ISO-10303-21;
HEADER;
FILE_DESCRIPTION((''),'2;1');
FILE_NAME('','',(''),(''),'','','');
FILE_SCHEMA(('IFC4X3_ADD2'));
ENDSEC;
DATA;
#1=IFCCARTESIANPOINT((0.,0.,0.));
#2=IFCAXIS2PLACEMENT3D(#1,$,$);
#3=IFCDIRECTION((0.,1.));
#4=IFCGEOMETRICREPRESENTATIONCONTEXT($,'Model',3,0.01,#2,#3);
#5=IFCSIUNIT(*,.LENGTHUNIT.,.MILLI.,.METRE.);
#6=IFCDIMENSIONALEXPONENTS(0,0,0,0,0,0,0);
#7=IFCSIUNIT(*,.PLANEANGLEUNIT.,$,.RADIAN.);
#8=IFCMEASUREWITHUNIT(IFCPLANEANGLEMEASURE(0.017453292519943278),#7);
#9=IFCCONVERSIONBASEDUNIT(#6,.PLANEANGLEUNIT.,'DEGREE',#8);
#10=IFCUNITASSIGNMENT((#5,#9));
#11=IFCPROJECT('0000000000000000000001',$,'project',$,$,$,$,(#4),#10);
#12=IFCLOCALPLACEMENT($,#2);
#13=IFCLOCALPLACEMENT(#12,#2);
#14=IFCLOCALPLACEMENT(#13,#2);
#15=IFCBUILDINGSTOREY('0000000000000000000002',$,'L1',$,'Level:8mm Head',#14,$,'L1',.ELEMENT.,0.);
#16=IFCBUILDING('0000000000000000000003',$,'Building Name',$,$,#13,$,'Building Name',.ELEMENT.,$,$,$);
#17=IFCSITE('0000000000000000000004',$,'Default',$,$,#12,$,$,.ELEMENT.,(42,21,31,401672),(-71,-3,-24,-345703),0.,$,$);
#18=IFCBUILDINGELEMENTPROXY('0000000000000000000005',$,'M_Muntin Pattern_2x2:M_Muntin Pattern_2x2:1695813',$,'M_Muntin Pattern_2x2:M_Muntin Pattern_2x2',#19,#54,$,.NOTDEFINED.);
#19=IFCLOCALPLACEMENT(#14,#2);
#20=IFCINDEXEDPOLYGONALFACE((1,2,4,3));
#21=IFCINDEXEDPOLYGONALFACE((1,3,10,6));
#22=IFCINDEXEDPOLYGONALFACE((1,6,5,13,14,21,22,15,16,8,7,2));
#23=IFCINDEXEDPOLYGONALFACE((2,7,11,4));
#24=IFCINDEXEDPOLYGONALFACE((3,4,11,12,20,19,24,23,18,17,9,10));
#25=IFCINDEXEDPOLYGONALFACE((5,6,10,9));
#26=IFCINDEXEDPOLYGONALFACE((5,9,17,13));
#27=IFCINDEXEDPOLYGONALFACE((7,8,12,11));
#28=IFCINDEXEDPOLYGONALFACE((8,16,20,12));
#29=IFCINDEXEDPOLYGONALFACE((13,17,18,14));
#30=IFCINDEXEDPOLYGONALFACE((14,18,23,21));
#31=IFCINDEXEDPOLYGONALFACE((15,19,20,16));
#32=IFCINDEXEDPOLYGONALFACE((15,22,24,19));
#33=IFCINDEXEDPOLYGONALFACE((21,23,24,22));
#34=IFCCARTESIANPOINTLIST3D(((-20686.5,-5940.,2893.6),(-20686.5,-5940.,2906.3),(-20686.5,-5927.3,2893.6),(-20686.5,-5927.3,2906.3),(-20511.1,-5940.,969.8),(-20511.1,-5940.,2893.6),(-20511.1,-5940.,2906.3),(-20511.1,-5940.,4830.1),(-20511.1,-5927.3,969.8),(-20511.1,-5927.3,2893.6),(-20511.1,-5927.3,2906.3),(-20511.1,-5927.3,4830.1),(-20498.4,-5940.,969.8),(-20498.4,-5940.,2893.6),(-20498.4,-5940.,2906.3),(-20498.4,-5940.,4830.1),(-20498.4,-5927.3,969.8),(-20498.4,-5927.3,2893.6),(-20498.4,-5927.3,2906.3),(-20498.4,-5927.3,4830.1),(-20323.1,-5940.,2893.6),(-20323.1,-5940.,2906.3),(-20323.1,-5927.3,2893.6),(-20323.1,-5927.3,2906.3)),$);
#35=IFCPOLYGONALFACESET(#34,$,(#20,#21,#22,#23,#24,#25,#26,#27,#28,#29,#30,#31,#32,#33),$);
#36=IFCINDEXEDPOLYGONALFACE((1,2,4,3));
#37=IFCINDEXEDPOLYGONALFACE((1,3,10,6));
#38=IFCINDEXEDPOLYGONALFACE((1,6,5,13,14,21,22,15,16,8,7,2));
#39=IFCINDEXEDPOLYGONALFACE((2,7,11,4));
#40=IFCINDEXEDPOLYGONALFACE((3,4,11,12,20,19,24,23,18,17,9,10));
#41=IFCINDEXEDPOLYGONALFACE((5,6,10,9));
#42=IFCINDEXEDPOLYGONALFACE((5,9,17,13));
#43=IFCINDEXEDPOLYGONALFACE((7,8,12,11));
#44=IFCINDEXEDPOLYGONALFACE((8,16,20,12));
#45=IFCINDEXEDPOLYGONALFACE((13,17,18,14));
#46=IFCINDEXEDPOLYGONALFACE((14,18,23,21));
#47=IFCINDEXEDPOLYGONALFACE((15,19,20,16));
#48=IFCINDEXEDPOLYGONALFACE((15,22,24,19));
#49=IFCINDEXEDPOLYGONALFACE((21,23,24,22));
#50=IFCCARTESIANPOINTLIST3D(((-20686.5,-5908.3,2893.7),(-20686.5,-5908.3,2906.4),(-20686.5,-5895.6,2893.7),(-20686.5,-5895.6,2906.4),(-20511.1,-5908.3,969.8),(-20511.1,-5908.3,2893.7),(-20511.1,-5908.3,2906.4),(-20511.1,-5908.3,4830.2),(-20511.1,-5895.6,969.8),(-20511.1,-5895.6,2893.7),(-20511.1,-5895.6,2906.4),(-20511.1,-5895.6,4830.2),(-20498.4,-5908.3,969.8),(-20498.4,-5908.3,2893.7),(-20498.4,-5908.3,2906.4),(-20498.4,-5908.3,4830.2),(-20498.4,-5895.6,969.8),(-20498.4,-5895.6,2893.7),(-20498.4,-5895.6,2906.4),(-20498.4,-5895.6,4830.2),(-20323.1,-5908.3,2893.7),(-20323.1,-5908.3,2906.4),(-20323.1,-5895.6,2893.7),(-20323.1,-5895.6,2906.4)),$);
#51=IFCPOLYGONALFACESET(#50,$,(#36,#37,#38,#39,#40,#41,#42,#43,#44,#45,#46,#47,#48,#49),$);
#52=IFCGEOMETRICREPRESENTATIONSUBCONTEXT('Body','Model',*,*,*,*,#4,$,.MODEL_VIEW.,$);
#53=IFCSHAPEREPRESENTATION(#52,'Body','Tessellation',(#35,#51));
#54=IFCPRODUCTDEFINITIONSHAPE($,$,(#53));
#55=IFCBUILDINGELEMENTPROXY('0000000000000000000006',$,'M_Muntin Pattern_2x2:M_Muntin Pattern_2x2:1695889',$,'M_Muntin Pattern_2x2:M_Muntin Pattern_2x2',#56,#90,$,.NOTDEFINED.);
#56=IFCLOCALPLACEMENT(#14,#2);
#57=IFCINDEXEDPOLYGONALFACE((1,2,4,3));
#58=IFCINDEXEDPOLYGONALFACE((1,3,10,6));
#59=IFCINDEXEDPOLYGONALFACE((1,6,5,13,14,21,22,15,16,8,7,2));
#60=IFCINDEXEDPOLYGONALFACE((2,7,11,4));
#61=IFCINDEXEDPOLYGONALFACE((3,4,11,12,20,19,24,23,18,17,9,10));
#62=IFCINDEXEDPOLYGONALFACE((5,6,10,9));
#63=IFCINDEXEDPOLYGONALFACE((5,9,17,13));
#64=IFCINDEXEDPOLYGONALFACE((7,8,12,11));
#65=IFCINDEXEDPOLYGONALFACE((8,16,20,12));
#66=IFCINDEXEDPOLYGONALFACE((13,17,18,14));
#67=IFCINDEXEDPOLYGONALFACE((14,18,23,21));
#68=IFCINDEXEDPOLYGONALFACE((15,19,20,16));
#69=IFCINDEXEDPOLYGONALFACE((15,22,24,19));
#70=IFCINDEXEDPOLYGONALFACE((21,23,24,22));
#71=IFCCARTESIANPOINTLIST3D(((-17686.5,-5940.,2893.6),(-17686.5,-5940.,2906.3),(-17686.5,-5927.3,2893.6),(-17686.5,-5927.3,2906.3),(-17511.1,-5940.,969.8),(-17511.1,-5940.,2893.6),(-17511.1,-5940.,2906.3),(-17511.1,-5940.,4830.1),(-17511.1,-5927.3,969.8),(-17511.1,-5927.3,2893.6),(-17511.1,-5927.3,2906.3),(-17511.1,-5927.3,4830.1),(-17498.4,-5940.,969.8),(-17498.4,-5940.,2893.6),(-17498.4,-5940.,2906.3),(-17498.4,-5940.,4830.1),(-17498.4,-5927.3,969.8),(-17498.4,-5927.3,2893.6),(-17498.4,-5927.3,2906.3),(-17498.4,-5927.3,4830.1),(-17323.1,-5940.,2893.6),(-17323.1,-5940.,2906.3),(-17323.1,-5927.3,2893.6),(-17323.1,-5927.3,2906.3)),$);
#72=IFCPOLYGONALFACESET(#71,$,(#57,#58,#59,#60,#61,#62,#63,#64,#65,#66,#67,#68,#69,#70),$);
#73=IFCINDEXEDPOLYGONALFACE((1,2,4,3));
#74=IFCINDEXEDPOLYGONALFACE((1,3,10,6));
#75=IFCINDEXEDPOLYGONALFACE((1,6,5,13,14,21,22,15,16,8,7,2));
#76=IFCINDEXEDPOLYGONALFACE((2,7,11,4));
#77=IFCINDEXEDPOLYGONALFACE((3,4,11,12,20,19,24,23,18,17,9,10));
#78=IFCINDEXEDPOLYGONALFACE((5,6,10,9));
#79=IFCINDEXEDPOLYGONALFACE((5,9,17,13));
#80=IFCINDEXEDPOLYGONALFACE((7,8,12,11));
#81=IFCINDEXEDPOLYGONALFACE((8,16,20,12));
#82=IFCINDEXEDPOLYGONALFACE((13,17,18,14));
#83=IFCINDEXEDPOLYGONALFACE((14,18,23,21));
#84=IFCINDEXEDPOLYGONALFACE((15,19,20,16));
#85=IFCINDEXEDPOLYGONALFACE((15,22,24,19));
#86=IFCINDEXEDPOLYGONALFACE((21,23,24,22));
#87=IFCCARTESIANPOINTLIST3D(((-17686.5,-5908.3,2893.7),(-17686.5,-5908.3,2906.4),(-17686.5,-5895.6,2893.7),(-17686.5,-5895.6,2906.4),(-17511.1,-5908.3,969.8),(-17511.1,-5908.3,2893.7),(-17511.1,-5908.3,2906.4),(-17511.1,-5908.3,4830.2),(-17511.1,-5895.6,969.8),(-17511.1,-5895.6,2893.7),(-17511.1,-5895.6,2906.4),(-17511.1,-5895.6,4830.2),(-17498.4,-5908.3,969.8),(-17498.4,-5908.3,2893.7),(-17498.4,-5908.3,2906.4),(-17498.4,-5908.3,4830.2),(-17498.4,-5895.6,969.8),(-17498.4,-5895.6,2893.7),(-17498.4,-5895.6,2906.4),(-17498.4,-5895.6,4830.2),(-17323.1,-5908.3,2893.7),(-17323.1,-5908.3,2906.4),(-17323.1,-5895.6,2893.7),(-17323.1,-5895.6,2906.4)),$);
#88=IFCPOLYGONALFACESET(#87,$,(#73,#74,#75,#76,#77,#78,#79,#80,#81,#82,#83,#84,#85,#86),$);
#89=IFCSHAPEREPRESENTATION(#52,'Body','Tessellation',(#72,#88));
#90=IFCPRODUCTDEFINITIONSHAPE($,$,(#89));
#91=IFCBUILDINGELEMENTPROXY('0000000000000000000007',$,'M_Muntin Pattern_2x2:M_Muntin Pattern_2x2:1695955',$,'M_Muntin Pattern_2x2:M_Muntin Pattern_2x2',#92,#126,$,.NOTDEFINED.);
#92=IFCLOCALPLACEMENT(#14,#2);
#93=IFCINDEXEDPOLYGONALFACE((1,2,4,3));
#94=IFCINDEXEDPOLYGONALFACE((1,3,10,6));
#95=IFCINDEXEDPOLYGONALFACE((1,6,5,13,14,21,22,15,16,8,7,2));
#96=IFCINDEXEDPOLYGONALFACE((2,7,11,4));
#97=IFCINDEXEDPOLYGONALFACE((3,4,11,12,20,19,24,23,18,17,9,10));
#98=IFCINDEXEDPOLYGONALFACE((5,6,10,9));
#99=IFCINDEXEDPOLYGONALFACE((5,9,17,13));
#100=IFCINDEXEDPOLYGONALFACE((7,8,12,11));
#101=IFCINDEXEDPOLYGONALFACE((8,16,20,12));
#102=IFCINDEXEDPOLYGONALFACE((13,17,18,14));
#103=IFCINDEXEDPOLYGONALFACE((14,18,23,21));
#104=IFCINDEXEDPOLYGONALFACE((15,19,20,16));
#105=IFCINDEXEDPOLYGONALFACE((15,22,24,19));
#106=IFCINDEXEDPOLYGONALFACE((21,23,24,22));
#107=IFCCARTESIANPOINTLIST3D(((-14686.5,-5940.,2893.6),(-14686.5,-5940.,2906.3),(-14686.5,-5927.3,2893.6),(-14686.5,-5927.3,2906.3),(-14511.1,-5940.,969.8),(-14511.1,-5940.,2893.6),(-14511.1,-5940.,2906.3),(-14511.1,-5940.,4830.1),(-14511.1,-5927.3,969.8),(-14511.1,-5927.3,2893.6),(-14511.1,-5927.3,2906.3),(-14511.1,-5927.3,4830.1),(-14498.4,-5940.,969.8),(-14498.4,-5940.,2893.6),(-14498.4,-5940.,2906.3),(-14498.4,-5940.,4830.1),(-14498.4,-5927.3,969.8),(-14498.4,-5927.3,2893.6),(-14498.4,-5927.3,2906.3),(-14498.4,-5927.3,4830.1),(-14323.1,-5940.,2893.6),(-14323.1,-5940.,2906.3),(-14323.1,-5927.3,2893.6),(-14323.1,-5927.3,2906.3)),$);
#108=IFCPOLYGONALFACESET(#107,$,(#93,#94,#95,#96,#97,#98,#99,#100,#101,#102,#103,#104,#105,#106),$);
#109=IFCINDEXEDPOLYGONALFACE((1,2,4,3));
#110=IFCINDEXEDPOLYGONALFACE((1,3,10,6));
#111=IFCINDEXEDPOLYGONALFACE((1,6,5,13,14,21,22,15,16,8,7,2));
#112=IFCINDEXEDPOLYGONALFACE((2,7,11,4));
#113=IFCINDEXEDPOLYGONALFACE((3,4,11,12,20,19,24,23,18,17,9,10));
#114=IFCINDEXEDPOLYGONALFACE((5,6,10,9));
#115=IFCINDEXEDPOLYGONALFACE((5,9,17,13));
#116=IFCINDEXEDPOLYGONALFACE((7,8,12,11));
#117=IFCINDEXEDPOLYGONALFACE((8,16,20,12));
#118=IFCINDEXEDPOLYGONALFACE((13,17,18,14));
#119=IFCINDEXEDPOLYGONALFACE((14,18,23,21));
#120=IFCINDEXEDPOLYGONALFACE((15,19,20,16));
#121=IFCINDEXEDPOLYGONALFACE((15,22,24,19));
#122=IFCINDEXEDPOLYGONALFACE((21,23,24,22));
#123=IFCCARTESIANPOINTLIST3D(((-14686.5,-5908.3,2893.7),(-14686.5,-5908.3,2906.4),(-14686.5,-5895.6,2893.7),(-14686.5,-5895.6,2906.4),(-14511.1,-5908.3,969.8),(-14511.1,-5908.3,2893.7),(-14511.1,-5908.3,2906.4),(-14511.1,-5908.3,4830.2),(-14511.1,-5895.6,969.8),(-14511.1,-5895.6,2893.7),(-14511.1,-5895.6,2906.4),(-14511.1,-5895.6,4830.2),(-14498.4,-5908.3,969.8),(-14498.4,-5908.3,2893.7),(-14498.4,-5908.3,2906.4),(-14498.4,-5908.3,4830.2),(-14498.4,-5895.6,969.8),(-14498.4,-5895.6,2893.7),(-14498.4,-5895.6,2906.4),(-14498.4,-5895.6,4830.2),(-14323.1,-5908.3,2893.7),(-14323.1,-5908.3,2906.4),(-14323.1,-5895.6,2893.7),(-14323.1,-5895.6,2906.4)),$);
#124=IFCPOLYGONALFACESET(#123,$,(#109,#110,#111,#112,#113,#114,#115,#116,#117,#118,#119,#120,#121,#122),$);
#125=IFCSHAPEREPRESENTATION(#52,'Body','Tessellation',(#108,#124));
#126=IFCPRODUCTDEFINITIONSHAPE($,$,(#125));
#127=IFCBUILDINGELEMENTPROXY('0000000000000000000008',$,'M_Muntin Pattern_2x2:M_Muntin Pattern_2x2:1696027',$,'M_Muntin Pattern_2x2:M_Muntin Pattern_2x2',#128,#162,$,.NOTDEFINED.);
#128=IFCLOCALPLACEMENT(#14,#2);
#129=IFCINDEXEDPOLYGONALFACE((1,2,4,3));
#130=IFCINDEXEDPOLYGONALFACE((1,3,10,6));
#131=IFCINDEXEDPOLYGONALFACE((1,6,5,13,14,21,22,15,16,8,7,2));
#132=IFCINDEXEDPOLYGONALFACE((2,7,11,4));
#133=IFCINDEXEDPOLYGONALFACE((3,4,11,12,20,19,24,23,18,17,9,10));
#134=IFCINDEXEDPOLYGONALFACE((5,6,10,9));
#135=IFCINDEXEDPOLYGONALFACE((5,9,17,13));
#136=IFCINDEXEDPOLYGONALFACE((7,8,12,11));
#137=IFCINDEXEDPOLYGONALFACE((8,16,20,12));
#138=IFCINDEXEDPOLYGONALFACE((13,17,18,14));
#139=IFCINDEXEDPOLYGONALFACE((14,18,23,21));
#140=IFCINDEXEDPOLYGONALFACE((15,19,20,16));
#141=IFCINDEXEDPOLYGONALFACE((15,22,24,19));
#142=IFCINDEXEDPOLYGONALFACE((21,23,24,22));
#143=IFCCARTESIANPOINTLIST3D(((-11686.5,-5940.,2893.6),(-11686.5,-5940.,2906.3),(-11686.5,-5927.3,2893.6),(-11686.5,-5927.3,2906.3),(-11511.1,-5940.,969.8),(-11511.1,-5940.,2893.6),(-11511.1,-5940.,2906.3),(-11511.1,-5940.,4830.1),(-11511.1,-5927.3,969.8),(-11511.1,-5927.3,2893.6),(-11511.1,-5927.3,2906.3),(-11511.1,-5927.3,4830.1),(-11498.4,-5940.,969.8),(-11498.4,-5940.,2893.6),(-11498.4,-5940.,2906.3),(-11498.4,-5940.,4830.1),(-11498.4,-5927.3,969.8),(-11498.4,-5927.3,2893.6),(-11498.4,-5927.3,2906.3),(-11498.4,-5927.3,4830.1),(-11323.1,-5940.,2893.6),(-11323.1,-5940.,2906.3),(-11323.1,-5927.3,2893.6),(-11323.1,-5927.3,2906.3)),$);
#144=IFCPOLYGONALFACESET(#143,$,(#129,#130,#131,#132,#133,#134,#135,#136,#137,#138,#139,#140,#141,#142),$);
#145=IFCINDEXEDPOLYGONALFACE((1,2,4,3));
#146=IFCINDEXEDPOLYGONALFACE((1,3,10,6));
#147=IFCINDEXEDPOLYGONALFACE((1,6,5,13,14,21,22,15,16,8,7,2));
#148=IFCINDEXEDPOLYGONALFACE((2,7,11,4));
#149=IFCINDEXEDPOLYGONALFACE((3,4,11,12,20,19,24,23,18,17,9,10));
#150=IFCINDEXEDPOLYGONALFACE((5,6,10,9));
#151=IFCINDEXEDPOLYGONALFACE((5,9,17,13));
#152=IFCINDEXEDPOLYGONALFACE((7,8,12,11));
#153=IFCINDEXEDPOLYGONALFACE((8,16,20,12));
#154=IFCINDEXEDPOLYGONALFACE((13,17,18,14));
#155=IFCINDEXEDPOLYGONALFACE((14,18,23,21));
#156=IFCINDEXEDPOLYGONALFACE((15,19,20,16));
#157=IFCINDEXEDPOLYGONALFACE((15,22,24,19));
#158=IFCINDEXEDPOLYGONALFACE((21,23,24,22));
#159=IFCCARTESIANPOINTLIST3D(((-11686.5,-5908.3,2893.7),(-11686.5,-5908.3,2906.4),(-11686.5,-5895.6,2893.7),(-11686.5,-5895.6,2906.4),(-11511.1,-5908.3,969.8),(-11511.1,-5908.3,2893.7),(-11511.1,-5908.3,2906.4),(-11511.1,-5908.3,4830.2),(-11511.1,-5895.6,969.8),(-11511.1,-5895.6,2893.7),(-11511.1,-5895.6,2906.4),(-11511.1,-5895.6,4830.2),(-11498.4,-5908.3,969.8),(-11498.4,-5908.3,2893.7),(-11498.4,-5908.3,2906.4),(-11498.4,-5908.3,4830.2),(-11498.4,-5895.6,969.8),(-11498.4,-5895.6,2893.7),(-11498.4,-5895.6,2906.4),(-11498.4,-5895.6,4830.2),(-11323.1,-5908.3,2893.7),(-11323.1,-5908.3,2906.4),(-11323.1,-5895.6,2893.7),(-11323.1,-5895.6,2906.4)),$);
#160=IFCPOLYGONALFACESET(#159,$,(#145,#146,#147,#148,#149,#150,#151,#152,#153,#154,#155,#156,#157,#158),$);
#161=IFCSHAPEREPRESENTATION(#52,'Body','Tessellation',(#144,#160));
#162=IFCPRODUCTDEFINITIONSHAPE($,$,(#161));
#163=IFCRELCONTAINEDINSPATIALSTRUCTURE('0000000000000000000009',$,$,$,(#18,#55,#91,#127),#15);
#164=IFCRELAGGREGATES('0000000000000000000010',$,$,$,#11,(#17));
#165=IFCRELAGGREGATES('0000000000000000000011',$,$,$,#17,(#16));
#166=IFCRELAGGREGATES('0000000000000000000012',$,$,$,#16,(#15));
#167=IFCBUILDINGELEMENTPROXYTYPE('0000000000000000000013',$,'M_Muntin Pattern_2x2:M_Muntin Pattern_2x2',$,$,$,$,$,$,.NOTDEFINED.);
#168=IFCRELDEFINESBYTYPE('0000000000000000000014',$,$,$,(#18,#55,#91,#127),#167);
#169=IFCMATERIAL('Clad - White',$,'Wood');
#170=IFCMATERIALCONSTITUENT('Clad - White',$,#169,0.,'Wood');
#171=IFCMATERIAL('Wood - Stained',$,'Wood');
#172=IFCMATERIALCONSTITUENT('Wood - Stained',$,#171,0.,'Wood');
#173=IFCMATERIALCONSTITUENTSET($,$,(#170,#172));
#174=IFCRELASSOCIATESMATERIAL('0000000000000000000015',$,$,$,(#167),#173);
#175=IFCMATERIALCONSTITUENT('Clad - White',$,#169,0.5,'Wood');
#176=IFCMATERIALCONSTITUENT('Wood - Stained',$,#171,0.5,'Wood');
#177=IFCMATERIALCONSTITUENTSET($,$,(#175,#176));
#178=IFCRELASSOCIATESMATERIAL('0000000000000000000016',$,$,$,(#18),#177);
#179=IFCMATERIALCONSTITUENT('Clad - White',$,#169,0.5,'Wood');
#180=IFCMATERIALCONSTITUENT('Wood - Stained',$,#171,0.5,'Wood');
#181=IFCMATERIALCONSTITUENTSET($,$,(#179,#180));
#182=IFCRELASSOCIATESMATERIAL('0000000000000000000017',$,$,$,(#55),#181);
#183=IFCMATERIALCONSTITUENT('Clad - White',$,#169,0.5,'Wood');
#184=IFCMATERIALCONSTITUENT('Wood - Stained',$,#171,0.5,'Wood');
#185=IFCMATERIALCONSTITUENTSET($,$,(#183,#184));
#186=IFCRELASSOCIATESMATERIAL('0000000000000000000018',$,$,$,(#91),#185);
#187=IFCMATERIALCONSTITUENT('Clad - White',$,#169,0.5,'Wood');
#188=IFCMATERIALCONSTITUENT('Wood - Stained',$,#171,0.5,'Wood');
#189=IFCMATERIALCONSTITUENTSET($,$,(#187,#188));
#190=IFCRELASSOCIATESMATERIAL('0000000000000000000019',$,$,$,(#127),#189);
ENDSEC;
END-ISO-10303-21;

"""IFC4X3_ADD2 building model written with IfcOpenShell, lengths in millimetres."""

from ifc_helpers import new_model, entity, si_unit, converted_unit, direction, frame, origin, place, context, subcontext, project, spatial, polyline, outline, extrude, source, transform, mapped, material, constituent, constituent_set, type_object, type_shapes, element, save


model = new_model("IFC4X3_ADD2")

# Units and contexts
model_context = context("Model", 3, precision=0.01, world=origin(), true_north=direction((0.0, 1.0)))
body_context = subcontext(model_context, "Body", "Model", "MODEL_VIEW")
ifc_project = project(units=[si_unit("LENGTHUNIT", "METRE", prefix="MILLI"), converted_unit("PLANEANGLEUNIT", "DEGREE", entity("IfcPlaneAngleMeasure", 0.017453292519943278), si_unit("PLANEANGLEUNIT", "RADIAN"), dimensions=[0, 0, 0, 0, 0, 0, 0])], contexts=[model_context])

# Site, building, storey
site_placement = place(None, origin())
site = spatial("IfcSite", under=ifc_project, at=site_placement, Name="Default", CompositionType="ELEMENT", RefLatitude=(42, 21, 31, 401672), RefLongitude=(-71, -3, -24, -345703), RefElevation=0.0)
building_placement = place(site_placement, origin())
building = spatial("IfcBuilding", under=site, at=building_placement, Name="Building Name", LongName="Building Name", CompositionType="ELEMENT")
storey_placement = place(building_placement, origin())
storey = spatial("IfcBuildingStorey", under=building, at=storey_placement, Name="L1", ObjectType="Level:8mm Head", LongName="L1", CompositionType="ELEMENT", Elevation=0.0)

# Building element proxies
ifc_material_1 = material(Name="Clad - White", Category="Wood")
ifc_material_2 = material(Name="Wood - Stained", Category="Wood")
ifc_constituent_1 = constituent(ifc_material_1, Name="Clad - White", Category="Wood", fraction=0.0)
ifc_constituent_2 = constituent(ifc_material_2, Name="Wood - Stained", Category="Wood", fraction=0.0)
ifc_constituent_set_1 = constituent_set(constituents=[ifc_constituent_1, ifc_constituent_2])
building_element_proxy_type_1 = type_object("IfcBuildingElementProxyType", Name="M_Muntin Pattern_2x2:M_Muntin Pattern_2x2", PredefinedType="NOTDEFINED", material=ifc_constituent_set_1)
shared_shape_1 = source(origin(), body_context, "Body", "SweptSolid", [
    extrude(outline(polyline([(6.4, -6.4), (1930.1, -6.4), (1930.1, 6.3), (6.4, 6.3), (6.4, 181.7), (-6.3, 181.7), (-6.3, 6.3), (-1930.2, 6.3), (-1930.2, -6.4), (-6.3, -6.4), (-6.3, -181.7), (6.4, -181.7), (6.4, -6.4)])), frame((0.0, 9.5, 1930.1), z_axis=(0.0, 1.0, 0.0), x_axis=(0.0, 0.0, 1.0)), (0.0, 0.0, 1.0), 12.7),
    extrude(outline(polyline([(6.4, -6.4), (1930.2, -6.4), (1930.2, 6.3), (6.4, 6.3), (6.4, 181.7), (-6.3, 181.7), (-6.3, 6.3), (-1930.2, 6.3), (-1930.2, -6.4), (-6.3, -6.4), (-6.3, -181.7), (6.4, -181.7), (6.4, -6.4)])), frame((0.0, -22.2, 1930.2), z_axis=(0.0, 1.0, 0.0), x_axis=(0.0, 0.0, 1.0)), (0.0, 0.0, 1.0), 12.7),
])
type_shapes(building_element_proxy_type_1, [shared_shape_1])
ifc_constituent_3 = constituent(ifc_material_1, Name="Clad - White", Category="Wood", fraction=0.5)
ifc_constituent_4 = constituent(ifc_material_2, Name="Wood - Stained", Category="Wood", fraction=0.5)
ifc_constituent_set_2 = constituent_set(constituents=[ifc_constituent_3, ifc_constituent_4])
proxy_1_placement = place(storey_placement, frame((-20504.8, -5917.8, 969.8), z_axis=(0.0, 0.0, 1.0), x_axis=(-1.0, 0.0, 0.0)))
element("IfcBuildingElementProxy", 1, at=proxy_1_placement, inside=storey, type_object=building_element_proxy_type_1, material=ifc_constituent_set_2, Name="M_Muntin Pattern_2x2:M_Muntin Pattern_2x2:1695813", ObjectType="M_Muntin Pattern_2x2:M_Muntin Pattern_2x2", PredefinedType="NOTDEFINED", context=body_context, shape_type="MappedRepresentation", body=[
    mapped(shared_shape_1, transform((0.0, 0.0, 0.0), scale=1.0)),
])
ifc_constituent_5 = constituent(ifc_material_1, Name="Clad - White", Category="Wood", fraction=0.5)
ifc_constituent_6 = constituent(ifc_material_2, Name="Wood - Stained", Category="Wood", fraction=0.5)
ifc_constituent_set_3 = constituent_set(constituents=[ifc_constituent_5, ifc_constituent_6])
proxy_2_placement = place(storey_placement, frame((-17504.8, -5917.8, 969.8), z_axis=(0.0, 0.0, 1.0), x_axis=(-1.0, 0.0, 0.0)))
element("IfcBuildingElementProxy", 2, at=proxy_2_placement, inside=storey, type_object=building_element_proxy_type_1, material=ifc_constituent_set_3, Name="M_Muntin Pattern_2x2:M_Muntin Pattern_2x2:1695889", ObjectType="M_Muntin Pattern_2x2:M_Muntin Pattern_2x2", PredefinedType="NOTDEFINED", context=body_context, shape_type="MappedRepresentation", body=[
    mapped(shared_shape_1, transform((0.0, 0.0, 0.0), scale=1.0)),
])
ifc_constituent_7 = constituent(ifc_material_1, Name="Clad - White", Category="Wood", fraction=0.5)
ifc_constituent_8 = constituent(ifc_material_2, Name="Wood - Stained", Category="Wood", fraction=0.5)
ifc_constituent_set_4 = constituent_set(constituents=[ifc_constituent_7, ifc_constituent_8])
proxy_3_placement = place(storey_placement, frame((-14504.8, -5917.8, 969.8), z_axis=(0.0, 0.0, 1.0), x_axis=(-1.0, 0.0, 0.0)))
element("IfcBuildingElementProxy", 3, at=proxy_3_placement, inside=storey, type_object=building_element_proxy_type_1, material=ifc_constituent_set_4, Name="M_Muntin Pattern_2x2:M_Muntin Pattern_2x2:1695955", ObjectType="M_Muntin Pattern_2x2:M_Muntin Pattern_2x2", PredefinedType="NOTDEFINED", context=body_context, shape_type="MappedRepresentation", body=[
    mapped(shared_shape_1, transform((0.0, 0.0, 0.0), scale=1.0)),
])
ifc_constituent_9 = constituent(ifc_material_1, Name="Clad - White", Category="Wood", fraction=0.5)
ifc_constituent_10 = constituent(ifc_material_2, Name="Wood - Stained", Category="Wood", fraction=0.5)
ifc_constituent_set_5 = constituent_set(constituents=[ifc_constituent_9, ifc_constituent_10])
proxy_4_placement = place(storey_placement, frame((-11504.8, -5917.8, 969.8), z_axis=(0.0, 0.0, 1.0), x_axis=(-1.0, 0.0, 0.0)))
element("IfcBuildingElementProxy", 4, at=proxy_4_placement, inside=storey, type_object=building_element_proxy_type_1, material=ifc_constituent_set_5, Name="M_Muntin Pattern_2x2:M_Muntin Pattern_2x2:1696027", ObjectType="M_Muntin Pattern_2x2:M_Muntin Pattern_2x2", PredefinedType="NOTDEFINED", context=body_context, shape_type="MappedRepresentation", body=[
    mapped(shared_shape_1, transform((0.0, 0.0, 0.0), scale=1.0)),
])

save(model, "model.ifc")
